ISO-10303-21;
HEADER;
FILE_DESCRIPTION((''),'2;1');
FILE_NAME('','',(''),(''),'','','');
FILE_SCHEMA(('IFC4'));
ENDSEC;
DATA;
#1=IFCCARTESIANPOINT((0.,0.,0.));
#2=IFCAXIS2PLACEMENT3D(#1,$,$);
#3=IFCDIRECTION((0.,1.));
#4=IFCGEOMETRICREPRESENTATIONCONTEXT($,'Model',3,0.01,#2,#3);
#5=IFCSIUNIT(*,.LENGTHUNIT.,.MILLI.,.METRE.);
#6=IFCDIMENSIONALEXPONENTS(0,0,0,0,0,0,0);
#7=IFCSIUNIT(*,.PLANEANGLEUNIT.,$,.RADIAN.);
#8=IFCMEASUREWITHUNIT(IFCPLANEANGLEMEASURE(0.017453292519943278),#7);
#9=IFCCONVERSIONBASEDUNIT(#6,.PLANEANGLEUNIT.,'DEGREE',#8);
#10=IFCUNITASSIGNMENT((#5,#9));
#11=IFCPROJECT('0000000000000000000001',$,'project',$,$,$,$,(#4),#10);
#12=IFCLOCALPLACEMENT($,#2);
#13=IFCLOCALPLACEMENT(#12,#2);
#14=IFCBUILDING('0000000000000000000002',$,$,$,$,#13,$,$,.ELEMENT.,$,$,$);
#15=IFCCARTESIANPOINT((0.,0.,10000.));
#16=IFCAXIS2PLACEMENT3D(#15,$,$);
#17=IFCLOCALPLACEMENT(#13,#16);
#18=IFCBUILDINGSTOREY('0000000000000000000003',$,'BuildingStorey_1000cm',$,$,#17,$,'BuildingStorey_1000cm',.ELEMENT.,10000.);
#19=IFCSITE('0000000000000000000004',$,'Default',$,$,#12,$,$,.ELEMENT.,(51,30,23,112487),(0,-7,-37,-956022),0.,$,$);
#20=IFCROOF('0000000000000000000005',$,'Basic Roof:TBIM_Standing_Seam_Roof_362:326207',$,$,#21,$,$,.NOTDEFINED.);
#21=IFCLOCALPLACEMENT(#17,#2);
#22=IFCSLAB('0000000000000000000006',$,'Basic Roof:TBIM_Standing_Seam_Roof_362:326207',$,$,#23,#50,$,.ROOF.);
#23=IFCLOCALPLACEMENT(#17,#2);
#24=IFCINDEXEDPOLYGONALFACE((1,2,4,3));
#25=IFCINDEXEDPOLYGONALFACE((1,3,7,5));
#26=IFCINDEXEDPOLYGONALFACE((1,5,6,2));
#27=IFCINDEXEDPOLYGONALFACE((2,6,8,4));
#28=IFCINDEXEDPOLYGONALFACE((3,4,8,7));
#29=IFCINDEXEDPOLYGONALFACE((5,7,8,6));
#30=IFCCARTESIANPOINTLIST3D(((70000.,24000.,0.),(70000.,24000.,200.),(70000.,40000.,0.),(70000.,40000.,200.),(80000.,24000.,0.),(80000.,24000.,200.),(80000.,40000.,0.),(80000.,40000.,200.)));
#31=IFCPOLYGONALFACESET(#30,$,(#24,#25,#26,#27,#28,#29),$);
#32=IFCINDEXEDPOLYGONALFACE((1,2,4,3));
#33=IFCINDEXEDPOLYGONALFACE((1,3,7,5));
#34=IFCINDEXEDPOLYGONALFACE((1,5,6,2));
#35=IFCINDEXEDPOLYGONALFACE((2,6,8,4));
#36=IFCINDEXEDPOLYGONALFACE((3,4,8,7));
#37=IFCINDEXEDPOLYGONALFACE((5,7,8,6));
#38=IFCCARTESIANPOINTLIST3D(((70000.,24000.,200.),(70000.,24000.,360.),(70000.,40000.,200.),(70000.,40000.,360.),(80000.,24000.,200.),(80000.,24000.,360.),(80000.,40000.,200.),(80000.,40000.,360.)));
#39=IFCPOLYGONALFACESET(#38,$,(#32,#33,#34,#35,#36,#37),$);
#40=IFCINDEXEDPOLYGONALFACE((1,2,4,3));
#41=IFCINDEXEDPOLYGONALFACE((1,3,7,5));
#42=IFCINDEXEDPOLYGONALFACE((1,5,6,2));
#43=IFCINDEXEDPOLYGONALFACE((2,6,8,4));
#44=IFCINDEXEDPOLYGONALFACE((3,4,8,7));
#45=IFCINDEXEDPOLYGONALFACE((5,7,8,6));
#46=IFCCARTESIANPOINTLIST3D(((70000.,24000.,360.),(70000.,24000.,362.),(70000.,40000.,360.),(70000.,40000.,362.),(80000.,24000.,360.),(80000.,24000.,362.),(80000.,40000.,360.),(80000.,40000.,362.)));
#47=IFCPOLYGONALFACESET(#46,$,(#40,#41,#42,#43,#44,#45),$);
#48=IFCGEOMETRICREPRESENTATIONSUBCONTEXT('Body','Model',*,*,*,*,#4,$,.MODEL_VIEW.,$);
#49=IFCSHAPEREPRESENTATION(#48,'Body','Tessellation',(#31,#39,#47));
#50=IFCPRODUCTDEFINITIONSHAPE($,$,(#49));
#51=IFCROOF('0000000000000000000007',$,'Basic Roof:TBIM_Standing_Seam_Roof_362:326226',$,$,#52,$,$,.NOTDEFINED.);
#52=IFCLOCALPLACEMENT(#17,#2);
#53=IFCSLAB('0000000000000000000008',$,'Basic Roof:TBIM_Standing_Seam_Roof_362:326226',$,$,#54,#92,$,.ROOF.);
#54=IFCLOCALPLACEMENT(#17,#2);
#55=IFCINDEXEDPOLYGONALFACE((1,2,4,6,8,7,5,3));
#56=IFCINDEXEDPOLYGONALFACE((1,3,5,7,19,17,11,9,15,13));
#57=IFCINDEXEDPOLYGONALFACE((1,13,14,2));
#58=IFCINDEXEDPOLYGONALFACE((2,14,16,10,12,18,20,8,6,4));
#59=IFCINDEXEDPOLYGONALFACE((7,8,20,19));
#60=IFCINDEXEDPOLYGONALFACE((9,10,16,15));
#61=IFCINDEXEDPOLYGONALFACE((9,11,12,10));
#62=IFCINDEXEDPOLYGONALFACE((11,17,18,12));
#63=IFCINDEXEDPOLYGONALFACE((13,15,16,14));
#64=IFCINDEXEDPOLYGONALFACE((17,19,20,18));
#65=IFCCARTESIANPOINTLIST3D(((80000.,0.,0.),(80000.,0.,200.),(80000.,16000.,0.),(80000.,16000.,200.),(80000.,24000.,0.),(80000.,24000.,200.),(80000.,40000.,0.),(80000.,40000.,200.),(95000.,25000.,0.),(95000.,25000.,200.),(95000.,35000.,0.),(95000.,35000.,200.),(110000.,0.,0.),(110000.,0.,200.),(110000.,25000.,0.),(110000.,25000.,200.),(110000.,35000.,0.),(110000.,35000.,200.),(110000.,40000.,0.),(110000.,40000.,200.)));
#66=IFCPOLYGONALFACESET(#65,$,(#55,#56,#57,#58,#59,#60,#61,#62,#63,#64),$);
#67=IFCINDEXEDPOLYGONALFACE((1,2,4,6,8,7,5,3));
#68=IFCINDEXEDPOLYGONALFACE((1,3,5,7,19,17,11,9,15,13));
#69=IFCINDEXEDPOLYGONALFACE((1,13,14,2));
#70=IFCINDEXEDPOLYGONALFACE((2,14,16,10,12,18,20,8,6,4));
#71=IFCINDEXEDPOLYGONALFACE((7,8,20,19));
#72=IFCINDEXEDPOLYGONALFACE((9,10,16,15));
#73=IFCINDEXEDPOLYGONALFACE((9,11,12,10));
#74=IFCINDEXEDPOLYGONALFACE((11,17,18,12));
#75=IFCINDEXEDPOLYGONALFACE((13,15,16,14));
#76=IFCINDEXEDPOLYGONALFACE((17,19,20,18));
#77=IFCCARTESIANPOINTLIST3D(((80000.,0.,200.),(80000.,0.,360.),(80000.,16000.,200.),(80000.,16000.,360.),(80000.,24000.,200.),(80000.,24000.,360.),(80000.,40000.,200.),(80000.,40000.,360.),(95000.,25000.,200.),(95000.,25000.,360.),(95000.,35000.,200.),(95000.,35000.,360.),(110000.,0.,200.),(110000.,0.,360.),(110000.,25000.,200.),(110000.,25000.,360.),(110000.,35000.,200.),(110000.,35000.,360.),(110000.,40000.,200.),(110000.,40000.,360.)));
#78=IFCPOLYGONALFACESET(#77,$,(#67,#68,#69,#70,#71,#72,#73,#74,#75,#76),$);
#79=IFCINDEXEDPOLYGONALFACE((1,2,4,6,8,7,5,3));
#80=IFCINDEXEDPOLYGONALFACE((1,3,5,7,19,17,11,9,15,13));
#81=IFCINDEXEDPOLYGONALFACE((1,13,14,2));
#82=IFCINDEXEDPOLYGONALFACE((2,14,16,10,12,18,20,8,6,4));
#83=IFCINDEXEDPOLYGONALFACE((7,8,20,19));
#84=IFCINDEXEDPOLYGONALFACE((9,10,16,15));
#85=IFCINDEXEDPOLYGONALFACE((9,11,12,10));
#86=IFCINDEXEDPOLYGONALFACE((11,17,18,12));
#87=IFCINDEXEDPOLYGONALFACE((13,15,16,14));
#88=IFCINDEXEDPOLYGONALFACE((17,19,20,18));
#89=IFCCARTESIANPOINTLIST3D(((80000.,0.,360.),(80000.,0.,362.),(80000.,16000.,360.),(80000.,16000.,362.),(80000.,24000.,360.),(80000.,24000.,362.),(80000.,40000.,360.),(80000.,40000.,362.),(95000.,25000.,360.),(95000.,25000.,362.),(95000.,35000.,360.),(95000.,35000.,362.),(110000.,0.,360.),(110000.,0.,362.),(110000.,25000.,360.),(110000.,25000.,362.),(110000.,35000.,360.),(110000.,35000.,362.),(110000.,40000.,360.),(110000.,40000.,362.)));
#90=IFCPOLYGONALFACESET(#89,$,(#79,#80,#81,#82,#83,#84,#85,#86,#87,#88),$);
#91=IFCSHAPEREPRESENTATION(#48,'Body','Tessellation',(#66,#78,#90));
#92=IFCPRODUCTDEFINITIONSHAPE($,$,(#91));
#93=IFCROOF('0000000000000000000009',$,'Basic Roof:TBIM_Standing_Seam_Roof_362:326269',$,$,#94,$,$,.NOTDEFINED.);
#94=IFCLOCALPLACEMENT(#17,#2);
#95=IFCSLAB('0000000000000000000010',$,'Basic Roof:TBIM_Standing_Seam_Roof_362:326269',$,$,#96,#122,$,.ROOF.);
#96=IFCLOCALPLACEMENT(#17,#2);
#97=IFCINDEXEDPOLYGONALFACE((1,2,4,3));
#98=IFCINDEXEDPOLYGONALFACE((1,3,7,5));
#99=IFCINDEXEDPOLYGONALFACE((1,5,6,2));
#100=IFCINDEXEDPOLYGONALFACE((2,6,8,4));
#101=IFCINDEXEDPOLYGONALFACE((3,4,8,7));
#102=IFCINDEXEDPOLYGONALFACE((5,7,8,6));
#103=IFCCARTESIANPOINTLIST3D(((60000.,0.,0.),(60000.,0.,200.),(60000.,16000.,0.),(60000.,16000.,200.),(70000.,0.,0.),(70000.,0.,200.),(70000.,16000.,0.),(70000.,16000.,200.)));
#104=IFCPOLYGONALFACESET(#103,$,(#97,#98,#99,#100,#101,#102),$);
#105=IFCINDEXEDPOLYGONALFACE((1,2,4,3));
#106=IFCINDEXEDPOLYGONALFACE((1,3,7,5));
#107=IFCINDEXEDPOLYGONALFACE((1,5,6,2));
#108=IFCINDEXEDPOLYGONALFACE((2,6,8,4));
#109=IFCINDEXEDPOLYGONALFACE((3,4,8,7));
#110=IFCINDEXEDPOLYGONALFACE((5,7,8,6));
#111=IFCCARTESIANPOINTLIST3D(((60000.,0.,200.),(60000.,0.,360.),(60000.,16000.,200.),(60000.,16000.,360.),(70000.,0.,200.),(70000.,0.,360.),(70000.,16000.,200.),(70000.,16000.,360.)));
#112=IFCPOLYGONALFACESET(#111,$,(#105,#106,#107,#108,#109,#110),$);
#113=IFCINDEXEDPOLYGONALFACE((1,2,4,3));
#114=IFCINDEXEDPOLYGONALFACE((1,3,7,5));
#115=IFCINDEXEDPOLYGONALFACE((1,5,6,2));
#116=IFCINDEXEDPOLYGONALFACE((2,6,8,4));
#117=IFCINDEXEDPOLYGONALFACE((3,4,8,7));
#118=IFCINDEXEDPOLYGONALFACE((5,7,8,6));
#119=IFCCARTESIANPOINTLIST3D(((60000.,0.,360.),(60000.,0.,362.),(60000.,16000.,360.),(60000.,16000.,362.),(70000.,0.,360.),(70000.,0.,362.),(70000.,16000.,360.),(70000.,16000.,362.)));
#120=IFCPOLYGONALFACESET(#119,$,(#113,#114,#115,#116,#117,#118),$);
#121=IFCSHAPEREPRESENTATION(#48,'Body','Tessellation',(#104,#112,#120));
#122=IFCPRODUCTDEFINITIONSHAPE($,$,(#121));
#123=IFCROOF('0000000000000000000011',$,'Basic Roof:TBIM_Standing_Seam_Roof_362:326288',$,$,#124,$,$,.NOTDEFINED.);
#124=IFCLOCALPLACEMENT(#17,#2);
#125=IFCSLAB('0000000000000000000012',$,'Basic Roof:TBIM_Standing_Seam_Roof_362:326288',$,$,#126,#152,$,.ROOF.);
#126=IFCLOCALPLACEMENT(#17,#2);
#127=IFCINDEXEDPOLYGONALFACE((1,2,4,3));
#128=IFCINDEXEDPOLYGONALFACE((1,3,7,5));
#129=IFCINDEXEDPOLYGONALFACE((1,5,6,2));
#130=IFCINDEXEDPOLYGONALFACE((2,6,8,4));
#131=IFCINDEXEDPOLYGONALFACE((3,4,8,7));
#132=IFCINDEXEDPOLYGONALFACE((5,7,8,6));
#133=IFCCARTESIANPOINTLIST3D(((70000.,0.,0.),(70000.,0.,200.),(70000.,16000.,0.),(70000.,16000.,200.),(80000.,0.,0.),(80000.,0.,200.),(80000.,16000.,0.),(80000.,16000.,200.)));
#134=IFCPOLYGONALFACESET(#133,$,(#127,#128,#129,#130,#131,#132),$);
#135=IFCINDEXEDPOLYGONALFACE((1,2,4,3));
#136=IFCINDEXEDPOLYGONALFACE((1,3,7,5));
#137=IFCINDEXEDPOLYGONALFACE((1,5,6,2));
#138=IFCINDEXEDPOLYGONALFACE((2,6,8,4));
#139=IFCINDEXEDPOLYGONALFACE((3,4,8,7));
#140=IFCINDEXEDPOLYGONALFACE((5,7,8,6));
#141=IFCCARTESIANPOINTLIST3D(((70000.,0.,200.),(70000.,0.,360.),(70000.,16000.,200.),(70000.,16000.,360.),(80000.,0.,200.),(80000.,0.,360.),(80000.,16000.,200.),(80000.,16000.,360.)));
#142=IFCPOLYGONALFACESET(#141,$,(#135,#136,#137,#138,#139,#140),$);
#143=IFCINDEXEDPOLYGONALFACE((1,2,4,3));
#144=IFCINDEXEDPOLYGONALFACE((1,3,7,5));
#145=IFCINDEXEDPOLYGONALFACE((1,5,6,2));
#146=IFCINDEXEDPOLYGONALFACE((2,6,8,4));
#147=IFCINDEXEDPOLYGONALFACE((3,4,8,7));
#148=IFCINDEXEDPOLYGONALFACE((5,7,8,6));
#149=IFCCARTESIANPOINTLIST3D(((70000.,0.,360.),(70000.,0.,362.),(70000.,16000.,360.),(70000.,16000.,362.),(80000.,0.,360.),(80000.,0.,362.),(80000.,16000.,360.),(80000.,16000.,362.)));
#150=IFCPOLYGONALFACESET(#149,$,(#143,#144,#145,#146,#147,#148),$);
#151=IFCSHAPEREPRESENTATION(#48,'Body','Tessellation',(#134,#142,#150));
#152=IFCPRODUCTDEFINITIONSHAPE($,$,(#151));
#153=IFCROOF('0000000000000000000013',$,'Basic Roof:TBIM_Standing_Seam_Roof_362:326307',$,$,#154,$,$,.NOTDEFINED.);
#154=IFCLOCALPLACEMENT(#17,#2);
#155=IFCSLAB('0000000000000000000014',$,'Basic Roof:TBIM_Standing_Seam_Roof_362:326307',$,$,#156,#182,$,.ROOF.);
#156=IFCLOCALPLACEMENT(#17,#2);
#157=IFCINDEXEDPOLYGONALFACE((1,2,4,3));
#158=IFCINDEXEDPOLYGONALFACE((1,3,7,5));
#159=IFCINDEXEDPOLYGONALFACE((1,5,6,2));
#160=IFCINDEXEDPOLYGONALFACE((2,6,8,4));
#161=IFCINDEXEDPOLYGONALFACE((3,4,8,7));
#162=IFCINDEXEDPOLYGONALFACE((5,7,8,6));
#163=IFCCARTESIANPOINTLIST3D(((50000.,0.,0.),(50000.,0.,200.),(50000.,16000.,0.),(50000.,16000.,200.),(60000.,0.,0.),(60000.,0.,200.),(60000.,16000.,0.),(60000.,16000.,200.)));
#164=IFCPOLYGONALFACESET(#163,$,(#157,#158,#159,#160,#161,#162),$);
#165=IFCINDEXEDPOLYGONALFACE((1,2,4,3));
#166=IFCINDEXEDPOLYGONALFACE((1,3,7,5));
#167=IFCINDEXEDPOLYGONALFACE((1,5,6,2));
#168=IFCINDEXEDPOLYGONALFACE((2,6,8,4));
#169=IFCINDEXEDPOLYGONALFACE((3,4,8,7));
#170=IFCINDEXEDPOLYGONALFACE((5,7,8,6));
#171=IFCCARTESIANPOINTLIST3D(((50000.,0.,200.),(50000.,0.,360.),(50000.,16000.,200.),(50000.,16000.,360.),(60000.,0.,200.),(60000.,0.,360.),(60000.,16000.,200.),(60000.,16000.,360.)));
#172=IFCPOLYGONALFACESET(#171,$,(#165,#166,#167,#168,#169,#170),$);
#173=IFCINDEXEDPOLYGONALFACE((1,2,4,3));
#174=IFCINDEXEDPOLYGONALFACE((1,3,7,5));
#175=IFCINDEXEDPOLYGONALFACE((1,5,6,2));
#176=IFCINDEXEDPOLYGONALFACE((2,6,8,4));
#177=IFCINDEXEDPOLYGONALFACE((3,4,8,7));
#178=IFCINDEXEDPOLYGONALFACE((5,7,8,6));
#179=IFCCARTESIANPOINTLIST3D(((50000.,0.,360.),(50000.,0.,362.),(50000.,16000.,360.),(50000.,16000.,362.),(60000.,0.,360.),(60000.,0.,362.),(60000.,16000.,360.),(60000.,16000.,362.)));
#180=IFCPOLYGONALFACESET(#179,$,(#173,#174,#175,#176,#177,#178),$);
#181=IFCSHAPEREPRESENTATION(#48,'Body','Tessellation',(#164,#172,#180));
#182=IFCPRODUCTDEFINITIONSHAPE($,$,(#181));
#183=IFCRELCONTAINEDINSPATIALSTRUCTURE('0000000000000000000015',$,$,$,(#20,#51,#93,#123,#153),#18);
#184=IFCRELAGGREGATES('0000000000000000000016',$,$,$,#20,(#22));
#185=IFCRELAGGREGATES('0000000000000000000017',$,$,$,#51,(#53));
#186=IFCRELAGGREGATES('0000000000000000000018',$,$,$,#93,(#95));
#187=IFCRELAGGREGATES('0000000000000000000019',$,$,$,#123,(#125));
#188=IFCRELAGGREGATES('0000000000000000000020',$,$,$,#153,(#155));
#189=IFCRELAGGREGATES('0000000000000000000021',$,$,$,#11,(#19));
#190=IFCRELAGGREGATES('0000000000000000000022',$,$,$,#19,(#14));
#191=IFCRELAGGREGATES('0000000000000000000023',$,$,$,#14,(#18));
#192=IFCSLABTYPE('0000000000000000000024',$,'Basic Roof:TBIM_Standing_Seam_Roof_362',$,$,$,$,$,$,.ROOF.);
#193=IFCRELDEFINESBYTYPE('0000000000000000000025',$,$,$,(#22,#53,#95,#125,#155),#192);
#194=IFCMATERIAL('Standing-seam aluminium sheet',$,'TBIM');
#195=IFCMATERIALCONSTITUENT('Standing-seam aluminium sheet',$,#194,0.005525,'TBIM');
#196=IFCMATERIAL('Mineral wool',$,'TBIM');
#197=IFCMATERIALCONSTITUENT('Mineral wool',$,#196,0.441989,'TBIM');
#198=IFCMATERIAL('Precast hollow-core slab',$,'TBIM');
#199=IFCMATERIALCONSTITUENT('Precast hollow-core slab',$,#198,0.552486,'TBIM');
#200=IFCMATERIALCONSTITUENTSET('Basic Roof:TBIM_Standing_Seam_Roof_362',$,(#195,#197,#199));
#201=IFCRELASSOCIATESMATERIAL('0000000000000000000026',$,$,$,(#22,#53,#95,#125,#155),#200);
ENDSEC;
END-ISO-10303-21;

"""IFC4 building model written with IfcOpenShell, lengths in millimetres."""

from ifc_helpers import new_model, entity, si_unit, converted_unit, direction, frame, origin, place, context, subcontext, project, spatial, indexed_curve, outline, extrude, material, constituent, constituent_set, type_object, element, aggregate, save


model = new_model("IFC4")

# Units and contexts
model_context = context("Model", 3, precision=0.01, world=origin(), true_north=direction((0.0, 1.0)))
body_context = subcontext(model_context, "Body", "Model", "MODEL_VIEW")
ifc_project = project(units=[si_unit("LENGTHUNIT", "METRE", prefix="MILLI"), converted_unit("PLANEANGLEUNIT", "DEGREE", entity("IfcPlaneAngleMeasure", 0.017453292519943278), si_unit("PLANEANGLEUNIT", "RADIAN"), dimensions=[0, 0, 0, 0, 0, 0, 0])], contexts=[model_context])

# Site, building, storey
site_placement = place(None, origin())
site = spatial("IfcSite", under=ifc_project, at=site_placement, Name="Default", CompositionType="ELEMENT", RefLatitude=(51, 30, 23, 112487), RefLongitude=(0, -7, -37, -956022), RefElevation=0.0)
building_placement = place(site_placement, origin())
building = spatial("IfcBuilding", under=site, at=building_placement, CompositionType="ELEMENT")
storey_placement = place(building_placement, frame((0.0, 0.0, 10000.0)))
storey = spatial("IfcBuildingStorey", under=building, at=storey_placement, Name="BuildingStorey_1000cm", LongName="BuildingStorey_1000cm", CompositionType="ELEMENT", Elevation=10000.0)

# Shared definitions
ifc_material_1 = material(Name="Precast hollow-core slab", Category="TBIM")

# Roofs, slabs
ifc_material_2 = material(Name="Standing-seam aluminium sheet", Category="TBIM")
ifc_constituent_1 = constituent(ifc_material_2, Name="Standing-seam aluminium sheet", Category="TBIM", fraction=0.005525)
ifc_material_3 = material(Name="Mineral wool", Category="TBIM")
ifc_constituent_2 = constituent(ifc_material_3, Name="Mineral wool", Category="TBIM", fraction=0.441989)
ifc_constituent_3 = constituent(ifc_material_1, Name="Precast hollow-core slab", Category="TBIM", fraction=0.552486)
ifc_constituent_set_1 = constituent_set(constituents=[ifc_constituent_1, ifc_constituent_2, ifc_constituent_3], Name="Basic Roof:TBIM_Standing_Seam_Roof_362")
slab_type_1 = type_object("IfcSlabType", Name="Basic Roof:TBIM_Standing_Seam_Roof_362", PredefinedType="ROOF")
roof_1_placement = place(storey_placement, frame((70000.0, 24000.0, 0.0)))
roof_1 = element("IfcRoof", 1, at=roof_1_placement, inside=storey, Name="Basic Roof:TBIM_Standing_Seam_Roof_362:326207", PredefinedType="NOTDEFINED")
slab_1_placement = place(roof_1_placement, origin())
slab_1 = element("IfcSlab", 2, at=slab_1_placement, type_object=slab_type_1, material=ifc_constituent_set_1, Name="Basic Roof:TBIM_Standing_Seam_Roof_362:326207", PredefinedType="ROOF", context=body_context, shape_type="SweptSolid", body=[
    extrude(outline(indexed_curve([(-5000.0, 8000.0), (-5000.0, -8000.0), (5000.0, -8000.0), (5000.0, 8000.0), (-5000.0, 8000.0)], self_intersect=False)), frame((5000.0, 8000.0, 0.0)), (0.0, 0.0, 1.0), 200.0),
    extrude(outline(indexed_curve([(-5000.0, 8000.0), (-5000.0, -8000.0), (5000.0, -8000.0), (5000.0, 8000.0), (-5000.0, 8000.0)], self_intersect=False)), frame((5000.0, 8000.0, 200.0)), (0.0, 0.0, 1.0), 160.0),
    extrude(outline(indexed_curve([(-5000.0, 8000.0), (-5000.0, -8000.0), (5000.0, -8000.0), (5000.0, 8000.0), (-5000.0, 8000.0)], self_intersect=False)), frame((5000.0, 8000.0, 360.0)), (0.0, 0.0, 1.0), 2.0),
])
aggregate(roof_1, [slab_1])
roof_2_placement = place(storey_placement, frame((80000.0, 0.0, 0.0)))
roof_2 = element("IfcRoof", 3, at=roof_2_placement, inside=storey, Name="Basic Roof:TBIM_Standing_Seam_Roof_362:326226", PredefinedType="NOTDEFINED")
slab_2_placement = place(roof_2_placement, origin())
slab_2 = element("IfcSlab", 4, at=slab_2_placement, type_object=slab_type_1, material=ifc_constituent_set_1, Name="Basic Roof:TBIM_Standing_Seam_Roof_362:326226", PredefinedType="ROOF", context=body_context, shape_type="SweptSolid", body=[
    extrude(outline(indexed_curve([(-15000.0, 20000.0), (-15000.0, 4000.0), (-15000.0, -4000.0), (-15000.0, -20000.0), (15000.0, -20000.0), (15000.0, 5000.0), (0.0, 5000.0), (0.0, 15000.0), (15000.0, 15000.0), (15000.0, 20000.0), (-15000.0, 20000.0)], self_intersect=False)), frame((15000.0, 20000.0, 0.0)), (0.0, 0.0, 1.0), 200.0),
    extrude(outline(indexed_curve([(-15000.0, 20000.0), (-15000.0, 4000.0), (-15000.0, -4000.0), (-15000.0, -20000.0), (15000.0, -20000.0), (15000.0, 5000.0), (0.0, 5000.0), (0.0, 15000.0), (15000.0, 15000.0), (15000.0, 20000.0), (-15000.0, 20000.0)], self_intersect=False)), frame((15000.0, 20000.0, 200.0)), (0.0, 0.0, 1.0), 160.0),
    extrude(outline(indexed_curve([(-15000.0, 20000.0), (-15000.0, 4000.0), (-15000.0, -4000.0), (-15000.0, -20000.0), (15000.0, -20000.0), (15000.0, 5000.0), (0.0, 5000.0), (0.0, 15000.0), (15000.0, 15000.0), (15000.0, 20000.0), (-15000.0, 20000.0)], self_intersect=False)), frame((15000.0, 20000.0, 360.0)), (0.0, 0.0, 1.0), 2.0),
])
aggregate(roof_2, [slab_2])
roof_3_placement = place(storey_placement, frame((60000.0, 0.0, 0.0)))
roof_3 = element("IfcRoof", 5, at=roof_3_placement, inside=storey, Name="Basic Roof:TBIM_Standing_Seam_Roof_362:326269", PredefinedType="NOTDEFINED")
slab_3_placement = place(roof_3_placement, origin())
slab_3 = element("IfcSlab", 6, at=slab_3_placement, type_object=slab_type_1, material=ifc_constituent_set_1, Name="Basic Roof:TBIM_Standing_Seam_Roof_362:326269", PredefinedType="ROOF", context=body_context, shape_type="SweptSolid", body=[
    extrude(outline(indexed_curve([(-5000.0, 8000.0), (-5000.0, -8000.0), (5000.0, -8000.0), (5000.0, 8000.0), (-5000.0, 8000.0)], self_intersect=False)), frame((5000.0, 8000.0, 0.0)), (0.0, 0.0, 1.0), 200.0),
    extrude(outline(indexed_curve([(-5000.0, 8000.0), (-5000.0, -8000.0), (5000.0, -8000.0), (5000.0, 8000.0), (-5000.0, 8000.0)], self_intersect=False)), frame((5000.0, 8000.0, 200.0)), (0.0, 0.0, 1.0), 160.0),
    extrude(outline(indexed_curve([(-5000.0, 8000.0), (-5000.0, -8000.0), (5000.0, -8000.0), (5000.0, 8000.0), (-5000.0, 8000.0)], self_intersect=False)), frame((5000.0, 8000.0, 360.0)), (0.0, 0.0, 1.0), 2.0),
])
aggregate(roof_3, [slab_3])
roof_4_placement = place(storey_placement, frame((70000.0, 0.0, 0.0)))
roof_4 = element("IfcRoof", 7, at=roof_4_placement, inside=storey, Name="Basic Roof:TBIM_Standing_Seam_Roof_362:326288", PredefinedType="NOTDEFINED")
slab_4_placement = place(roof_4_placement, origin())
slab_4 = element("IfcSlab", 8, at=slab_4_placement, type_object=slab_type_1, material=ifc_constituent_set_1, Name="Basic Roof:TBIM_Standing_Seam_Roof_362:326288", PredefinedType="ROOF", context=body_context, shape_type="SweptSolid", body=[
    extrude(outline(indexed_curve([(-5000.0, 8000.0), (-5000.0, -8000.0), (5000.0, -8000.0), (5000.0, 8000.0), (-5000.0, 8000.0)], self_intersect=False)), frame((5000.0, 8000.0, 0.0)), (0.0, 0.0, 1.0), 200.0),
    extrude(outline(indexed_curve([(-5000.0, 8000.0), (-5000.0, -8000.0), (5000.0, -8000.0), (5000.0, 8000.0), (-5000.0, 8000.0)], self_intersect=False)), frame((5000.0, 8000.0, 200.0)), (0.0, 0.0, 1.0), 160.0),
    extrude(outline(indexed_curve([(-5000.0, 8000.0), (-5000.0, -8000.0), (5000.0, -8000.0), (5000.0, 8000.0), (-5000.0, 8000.0)], self_intersect=False)), frame((5000.0, 8000.0, 360.0)), (0.0, 0.0, 1.0), 2.0),
])
aggregate(roof_4, [slab_4])
roof_5_placement = place(storey_placement, frame((50000.0, 0.0, 0.0)))
roof_5 = element("IfcRoof", 9, at=roof_5_placement, inside=storey, Name="Basic Roof:TBIM_Standing_Seam_Roof_362:326307", PredefinedType="NOTDEFINED")
slab_5_placement = place(roof_5_placement, origin())
slab_5 = element("IfcSlab", 10, at=slab_5_placement, type_object=slab_type_1, material=ifc_constituent_set_1, Name="Basic Roof:TBIM_Standing_Seam_Roof_362:326307", PredefinedType="ROOF", context=body_context, shape_type="SweptSolid", body=[
    extrude(outline(indexed_curve([(-5000.0, 8000.0), (-5000.0, -8000.0), (5000.0, -8000.0), (5000.0, 8000.0), (-5000.0, 8000.0)], self_intersect=False)), frame((5000.0, 8000.0, 0.0)), (0.0, 0.0, 1.0), 200.0),
    extrude(outline(indexed_curve([(-5000.0, 8000.0), (-5000.0, -8000.0), (5000.0, -8000.0), (5000.0, 8000.0), (-5000.0, 8000.0)], self_intersect=False)), frame((5000.0, 8000.0, 200.0)), (0.0, 0.0, 1.0), 160.0),
    extrude(outline(indexed_curve([(-5000.0, 8000.0), (-5000.0, -8000.0), (5000.0, -8000.0), (5000.0, 8000.0), (-5000.0, 8000.0)], self_intersect=False)), frame((5000.0, 8000.0, 360.0)), (0.0, 0.0, 1.0), 2.0),
])
aggregate(roof_5, [slab_5])

save(model, "model.ifc")
